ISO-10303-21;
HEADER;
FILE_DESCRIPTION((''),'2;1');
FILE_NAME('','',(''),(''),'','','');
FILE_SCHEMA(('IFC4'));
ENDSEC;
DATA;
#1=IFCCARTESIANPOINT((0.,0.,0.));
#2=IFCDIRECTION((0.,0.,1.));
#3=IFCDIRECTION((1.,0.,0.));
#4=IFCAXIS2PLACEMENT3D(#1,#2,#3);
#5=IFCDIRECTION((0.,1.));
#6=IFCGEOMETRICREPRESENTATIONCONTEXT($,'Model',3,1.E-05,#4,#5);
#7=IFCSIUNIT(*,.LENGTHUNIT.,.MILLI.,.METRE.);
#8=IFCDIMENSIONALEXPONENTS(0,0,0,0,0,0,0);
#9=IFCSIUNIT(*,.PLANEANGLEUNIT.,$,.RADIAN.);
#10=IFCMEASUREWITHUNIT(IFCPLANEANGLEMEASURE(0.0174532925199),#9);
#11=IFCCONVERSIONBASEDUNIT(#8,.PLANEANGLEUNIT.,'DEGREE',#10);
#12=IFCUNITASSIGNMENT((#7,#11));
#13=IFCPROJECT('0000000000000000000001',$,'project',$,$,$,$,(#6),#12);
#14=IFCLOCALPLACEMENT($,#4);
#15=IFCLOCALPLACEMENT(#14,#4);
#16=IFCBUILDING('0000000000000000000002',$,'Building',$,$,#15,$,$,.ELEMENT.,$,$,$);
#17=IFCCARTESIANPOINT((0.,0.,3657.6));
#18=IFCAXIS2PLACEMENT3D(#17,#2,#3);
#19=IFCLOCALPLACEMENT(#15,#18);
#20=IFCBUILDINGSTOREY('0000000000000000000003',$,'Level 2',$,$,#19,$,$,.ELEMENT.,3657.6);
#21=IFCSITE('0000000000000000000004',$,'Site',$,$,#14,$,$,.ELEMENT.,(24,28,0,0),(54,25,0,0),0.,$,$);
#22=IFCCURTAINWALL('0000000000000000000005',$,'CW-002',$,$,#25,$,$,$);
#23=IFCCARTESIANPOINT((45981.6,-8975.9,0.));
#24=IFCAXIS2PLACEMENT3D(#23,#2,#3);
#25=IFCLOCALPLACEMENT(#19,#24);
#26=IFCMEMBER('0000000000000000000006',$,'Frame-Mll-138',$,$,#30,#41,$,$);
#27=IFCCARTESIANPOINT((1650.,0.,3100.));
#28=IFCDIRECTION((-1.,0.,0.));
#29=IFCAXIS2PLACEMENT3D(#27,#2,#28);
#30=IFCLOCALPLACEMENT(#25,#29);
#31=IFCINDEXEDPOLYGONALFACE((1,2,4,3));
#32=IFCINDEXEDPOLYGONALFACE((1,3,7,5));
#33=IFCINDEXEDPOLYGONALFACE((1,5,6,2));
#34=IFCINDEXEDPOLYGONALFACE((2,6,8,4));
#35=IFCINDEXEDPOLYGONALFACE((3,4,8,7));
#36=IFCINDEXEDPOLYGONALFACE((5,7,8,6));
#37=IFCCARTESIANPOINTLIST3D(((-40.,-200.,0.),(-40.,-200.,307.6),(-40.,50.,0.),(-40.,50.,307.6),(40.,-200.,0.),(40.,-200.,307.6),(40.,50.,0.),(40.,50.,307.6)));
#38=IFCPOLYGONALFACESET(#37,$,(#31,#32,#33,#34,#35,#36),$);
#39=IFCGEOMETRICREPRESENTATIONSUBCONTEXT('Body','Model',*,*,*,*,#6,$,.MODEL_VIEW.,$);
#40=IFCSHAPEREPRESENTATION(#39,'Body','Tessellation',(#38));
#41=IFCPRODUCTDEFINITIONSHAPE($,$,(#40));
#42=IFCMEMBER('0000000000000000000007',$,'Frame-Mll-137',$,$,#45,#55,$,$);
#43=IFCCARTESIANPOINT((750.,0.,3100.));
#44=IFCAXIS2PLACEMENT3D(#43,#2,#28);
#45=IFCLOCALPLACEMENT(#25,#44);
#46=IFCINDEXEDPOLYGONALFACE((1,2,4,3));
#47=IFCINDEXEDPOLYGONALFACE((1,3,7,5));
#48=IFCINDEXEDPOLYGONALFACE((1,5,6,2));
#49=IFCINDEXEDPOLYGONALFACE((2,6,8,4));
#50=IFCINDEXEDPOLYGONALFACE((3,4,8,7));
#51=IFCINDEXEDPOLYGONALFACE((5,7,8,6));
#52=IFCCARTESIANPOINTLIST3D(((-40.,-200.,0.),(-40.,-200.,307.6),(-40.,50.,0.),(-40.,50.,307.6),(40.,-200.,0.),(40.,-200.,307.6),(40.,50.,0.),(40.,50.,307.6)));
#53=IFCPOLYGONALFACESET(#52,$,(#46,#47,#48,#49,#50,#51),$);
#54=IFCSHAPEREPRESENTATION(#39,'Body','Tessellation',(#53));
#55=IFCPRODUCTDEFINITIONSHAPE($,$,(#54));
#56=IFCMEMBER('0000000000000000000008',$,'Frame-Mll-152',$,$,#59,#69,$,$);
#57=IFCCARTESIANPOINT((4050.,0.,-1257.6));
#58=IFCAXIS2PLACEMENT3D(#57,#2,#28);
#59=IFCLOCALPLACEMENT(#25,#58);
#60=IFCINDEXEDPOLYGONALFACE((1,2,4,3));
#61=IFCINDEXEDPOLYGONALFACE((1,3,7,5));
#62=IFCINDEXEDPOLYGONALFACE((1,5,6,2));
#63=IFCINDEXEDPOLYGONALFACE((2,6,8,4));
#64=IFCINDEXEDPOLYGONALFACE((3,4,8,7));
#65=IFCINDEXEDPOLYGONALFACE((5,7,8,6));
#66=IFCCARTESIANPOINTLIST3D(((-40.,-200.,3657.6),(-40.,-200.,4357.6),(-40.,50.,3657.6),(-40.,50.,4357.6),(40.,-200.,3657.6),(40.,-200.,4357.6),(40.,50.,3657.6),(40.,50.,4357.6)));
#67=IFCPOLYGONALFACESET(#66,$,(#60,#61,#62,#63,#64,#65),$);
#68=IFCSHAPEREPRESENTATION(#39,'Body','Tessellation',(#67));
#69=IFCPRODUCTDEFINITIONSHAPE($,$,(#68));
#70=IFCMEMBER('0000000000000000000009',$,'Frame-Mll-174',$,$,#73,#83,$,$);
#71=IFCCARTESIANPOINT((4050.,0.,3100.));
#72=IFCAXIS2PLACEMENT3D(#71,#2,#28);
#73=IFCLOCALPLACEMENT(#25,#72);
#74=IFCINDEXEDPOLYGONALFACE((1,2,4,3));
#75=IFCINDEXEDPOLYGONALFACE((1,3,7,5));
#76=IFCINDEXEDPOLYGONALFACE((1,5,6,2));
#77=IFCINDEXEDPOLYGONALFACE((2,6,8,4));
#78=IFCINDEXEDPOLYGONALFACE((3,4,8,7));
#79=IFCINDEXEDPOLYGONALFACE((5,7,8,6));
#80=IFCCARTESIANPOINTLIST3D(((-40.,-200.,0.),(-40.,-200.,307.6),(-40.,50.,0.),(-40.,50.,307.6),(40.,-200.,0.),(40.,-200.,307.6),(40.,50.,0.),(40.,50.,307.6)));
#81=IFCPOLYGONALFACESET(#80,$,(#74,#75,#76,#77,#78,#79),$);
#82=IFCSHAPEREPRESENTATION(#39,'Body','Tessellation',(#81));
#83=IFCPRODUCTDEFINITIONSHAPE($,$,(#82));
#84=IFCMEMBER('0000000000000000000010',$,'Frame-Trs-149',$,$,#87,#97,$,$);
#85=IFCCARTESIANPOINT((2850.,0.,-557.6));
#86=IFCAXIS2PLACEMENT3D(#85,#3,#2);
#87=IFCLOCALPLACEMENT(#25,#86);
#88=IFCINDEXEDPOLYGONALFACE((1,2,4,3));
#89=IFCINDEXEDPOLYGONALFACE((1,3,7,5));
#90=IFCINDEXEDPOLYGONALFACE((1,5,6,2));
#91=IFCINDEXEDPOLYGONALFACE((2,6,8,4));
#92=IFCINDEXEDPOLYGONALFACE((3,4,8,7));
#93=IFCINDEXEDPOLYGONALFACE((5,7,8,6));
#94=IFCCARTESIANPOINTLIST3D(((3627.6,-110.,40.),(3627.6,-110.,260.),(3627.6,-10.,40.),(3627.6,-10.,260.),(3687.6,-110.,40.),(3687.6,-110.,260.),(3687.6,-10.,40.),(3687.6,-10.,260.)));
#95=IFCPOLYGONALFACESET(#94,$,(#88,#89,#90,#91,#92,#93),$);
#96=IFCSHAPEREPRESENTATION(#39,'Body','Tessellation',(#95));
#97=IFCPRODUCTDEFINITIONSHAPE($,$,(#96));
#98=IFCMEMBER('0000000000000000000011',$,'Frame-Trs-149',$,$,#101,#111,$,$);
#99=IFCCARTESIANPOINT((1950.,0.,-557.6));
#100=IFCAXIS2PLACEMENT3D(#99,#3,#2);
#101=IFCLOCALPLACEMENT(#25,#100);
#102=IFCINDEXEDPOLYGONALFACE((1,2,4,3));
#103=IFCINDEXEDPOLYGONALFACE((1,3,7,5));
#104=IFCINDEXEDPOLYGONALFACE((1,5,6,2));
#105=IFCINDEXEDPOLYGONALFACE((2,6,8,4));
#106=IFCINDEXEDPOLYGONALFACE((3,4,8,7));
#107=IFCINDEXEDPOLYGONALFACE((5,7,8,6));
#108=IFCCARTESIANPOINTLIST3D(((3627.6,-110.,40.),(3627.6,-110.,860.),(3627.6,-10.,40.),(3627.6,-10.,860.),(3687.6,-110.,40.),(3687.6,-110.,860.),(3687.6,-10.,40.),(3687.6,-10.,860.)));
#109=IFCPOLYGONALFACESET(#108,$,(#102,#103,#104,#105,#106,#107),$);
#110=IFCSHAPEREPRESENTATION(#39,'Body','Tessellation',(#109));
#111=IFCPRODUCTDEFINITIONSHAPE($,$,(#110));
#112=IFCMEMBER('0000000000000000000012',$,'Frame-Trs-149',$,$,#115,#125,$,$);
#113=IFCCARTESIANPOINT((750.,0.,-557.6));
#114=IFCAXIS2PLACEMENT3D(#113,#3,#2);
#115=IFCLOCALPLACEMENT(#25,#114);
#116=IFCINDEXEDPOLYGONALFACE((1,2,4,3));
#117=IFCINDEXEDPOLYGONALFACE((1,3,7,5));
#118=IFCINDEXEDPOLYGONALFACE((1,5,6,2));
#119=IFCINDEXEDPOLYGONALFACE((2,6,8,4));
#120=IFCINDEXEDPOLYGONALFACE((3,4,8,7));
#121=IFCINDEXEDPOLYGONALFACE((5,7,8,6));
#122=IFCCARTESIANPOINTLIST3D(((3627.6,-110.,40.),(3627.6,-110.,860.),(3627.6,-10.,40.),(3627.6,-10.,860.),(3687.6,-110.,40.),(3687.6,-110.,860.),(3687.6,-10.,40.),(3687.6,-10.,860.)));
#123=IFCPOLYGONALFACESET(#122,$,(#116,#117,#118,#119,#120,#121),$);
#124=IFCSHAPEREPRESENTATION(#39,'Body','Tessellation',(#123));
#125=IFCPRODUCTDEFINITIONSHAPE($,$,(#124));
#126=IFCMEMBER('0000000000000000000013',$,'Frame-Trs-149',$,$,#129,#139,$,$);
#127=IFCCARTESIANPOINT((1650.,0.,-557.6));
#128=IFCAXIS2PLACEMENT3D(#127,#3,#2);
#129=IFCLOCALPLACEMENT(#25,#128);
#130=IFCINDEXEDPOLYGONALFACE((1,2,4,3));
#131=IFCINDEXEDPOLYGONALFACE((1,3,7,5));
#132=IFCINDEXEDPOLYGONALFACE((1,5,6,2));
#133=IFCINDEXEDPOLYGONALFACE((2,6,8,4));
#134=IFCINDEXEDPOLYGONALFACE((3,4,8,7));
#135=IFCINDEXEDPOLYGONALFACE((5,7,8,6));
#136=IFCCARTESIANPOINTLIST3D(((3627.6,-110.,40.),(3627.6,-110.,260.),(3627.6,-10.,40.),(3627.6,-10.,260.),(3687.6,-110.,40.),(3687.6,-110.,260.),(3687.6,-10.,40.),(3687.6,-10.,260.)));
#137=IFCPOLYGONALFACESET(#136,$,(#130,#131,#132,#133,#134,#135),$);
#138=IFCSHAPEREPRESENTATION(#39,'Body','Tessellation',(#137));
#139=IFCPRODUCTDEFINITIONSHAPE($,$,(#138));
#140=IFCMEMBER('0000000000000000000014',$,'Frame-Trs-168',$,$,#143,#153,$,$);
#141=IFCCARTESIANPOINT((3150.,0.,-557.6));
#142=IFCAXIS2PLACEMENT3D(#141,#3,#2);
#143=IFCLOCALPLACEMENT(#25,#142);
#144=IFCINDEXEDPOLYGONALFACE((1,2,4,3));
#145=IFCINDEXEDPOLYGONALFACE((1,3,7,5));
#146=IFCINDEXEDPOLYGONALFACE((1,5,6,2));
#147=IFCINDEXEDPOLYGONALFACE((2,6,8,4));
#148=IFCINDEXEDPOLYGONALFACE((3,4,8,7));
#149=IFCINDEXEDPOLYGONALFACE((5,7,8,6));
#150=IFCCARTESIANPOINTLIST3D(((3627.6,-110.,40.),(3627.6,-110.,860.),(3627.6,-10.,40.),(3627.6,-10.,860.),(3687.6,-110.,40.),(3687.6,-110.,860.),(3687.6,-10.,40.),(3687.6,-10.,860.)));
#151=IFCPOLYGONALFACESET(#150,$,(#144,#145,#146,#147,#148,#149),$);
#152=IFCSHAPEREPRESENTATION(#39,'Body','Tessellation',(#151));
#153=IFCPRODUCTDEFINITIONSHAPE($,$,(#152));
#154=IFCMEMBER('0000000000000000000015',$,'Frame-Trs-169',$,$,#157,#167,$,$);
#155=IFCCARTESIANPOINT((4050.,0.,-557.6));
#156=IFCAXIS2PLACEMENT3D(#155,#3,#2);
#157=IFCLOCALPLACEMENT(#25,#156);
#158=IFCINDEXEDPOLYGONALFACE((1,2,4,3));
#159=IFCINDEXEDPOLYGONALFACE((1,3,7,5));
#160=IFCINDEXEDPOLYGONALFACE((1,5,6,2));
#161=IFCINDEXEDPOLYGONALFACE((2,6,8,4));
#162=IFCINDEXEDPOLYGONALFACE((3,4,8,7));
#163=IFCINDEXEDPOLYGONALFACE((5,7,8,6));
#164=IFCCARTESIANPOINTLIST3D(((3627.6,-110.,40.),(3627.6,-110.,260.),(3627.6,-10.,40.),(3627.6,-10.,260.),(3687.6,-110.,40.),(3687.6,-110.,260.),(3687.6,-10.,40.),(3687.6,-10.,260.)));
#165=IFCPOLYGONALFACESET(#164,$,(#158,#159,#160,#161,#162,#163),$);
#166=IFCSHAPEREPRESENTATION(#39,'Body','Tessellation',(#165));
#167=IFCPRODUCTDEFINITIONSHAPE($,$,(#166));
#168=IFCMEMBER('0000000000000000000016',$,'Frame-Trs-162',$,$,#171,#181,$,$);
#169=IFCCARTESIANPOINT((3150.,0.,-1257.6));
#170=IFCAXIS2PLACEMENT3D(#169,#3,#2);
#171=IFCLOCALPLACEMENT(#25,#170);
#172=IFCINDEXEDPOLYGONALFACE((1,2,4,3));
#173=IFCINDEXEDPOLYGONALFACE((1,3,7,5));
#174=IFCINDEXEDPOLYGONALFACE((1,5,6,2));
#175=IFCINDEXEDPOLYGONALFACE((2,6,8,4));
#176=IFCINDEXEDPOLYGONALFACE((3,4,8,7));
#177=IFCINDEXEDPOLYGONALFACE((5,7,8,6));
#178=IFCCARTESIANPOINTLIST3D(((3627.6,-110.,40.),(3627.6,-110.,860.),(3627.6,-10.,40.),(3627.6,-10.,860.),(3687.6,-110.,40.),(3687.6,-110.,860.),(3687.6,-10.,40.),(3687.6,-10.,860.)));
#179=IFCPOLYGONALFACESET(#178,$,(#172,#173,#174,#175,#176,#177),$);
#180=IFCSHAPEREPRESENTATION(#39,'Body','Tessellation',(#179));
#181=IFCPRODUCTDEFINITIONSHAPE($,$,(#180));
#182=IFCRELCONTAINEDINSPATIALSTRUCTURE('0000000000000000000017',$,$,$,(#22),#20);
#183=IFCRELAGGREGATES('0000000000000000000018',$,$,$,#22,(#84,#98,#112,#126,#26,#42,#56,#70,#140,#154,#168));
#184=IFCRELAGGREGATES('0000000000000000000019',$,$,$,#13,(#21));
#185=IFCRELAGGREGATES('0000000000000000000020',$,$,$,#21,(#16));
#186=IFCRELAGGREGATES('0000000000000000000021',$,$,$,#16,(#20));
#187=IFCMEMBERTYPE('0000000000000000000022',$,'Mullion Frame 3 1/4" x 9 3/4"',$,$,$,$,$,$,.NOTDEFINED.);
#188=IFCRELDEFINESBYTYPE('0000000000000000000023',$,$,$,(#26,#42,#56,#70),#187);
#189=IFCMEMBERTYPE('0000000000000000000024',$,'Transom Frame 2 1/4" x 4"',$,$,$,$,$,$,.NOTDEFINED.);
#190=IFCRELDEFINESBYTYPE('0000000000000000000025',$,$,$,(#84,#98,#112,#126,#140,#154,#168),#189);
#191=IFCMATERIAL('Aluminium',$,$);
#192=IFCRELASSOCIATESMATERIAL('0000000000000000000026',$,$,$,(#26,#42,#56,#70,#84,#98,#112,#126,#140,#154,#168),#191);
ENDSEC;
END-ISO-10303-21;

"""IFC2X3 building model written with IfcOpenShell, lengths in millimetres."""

from ifc_helpers import new_model, entity, si_unit, converted_unit, direction, frame, origin_with_axes, place, context, subcontext, project, spatial, polyline, outline, extrude, material, type_object, element, aggregate, save


model = new_model("IFC2X3")

# Units and contexts
model_context = context("Model", 3, precision=1e-05, world=origin_with_axes(), true_north=direction((0.0, 1.0)))
body_context = subcontext(model_context, "Body", "Model", "MODEL_VIEW")
ifc_project = project(units=[si_unit("LENGTHUNIT", "METRE", prefix="MILLI"), converted_unit("PLANEANGLEUNIT", "DEGREE", entity("IfcPlaneAngleMeasure", 0.0174532925199), si_unit("PLANEANGLEUNIT", "RADIAN"), dimensions=[0, 0, 0, 0, 0, 0, 0])], contexts=[model_context])

# Site, building, storey
site_placement = place(None, origin_with_axes())
site = spatial("IfcSite", under=ifc_project, at=site_placement, Name="Site", CompositionType="ELEMENT", RefLatitude=(24, 28, 0, 0), RefLongitude=(54, 25, 0, 0), RefElevation=0.0)
building_placement = place(site_placement, origin_with_axes())
building = spatial("IfcBuilding", under=site, at=building_placement, Name="Building", CompositionType="ELEMENT")
storey_placement = place(building_placement, frame((0.0, 0.0, 3657.6), z_axis=(0.0, 0.0, 1.0), x_axis=(1.0, 0.0, 0.0)))
storey = spatial("IfcBuildingStorey", under=building, at=storey_placement, Name="Level 2", CompositionType="ELEMENT", Elevation=3657.6)

# Curtain wall, members
curtain_wall_placement = place(storey_placement, frame((45981.6, -8975.9, 0.0), z_axis=(0.0, 0.0, 1.0), x_axis=(1.0, 0.0, 0.0)))
curtain_wall = element("IfcCurtainWall", 1, at=curtain_wall_placement, inside=storey, Name="CW-002")
ifc_material_1 = material(Name="Aluminium")
member_type_1 = type_object("IfcMemberType", Name="Mullion Frame 3 1/4\" x 9 3/4\"", PredefinedType="NOTDEFINED")
member_1_placement = place(curtain_wall_placement, frame((1650.0, 0.0, 3100.0), z_axis=(0.0, 0.0, 1.0), x_axis=(-1.0, 0.0, 0.0)))
member_1 = element("IfcMember", 2, at=member_1_placement, type_object=member_type_1, material=ifc_material_1, Name="Frame-Mll-138", context=body_context, shape_type="SweptSolid", body=[
    extrude(outline(polyline([(-40.0, 200.0), (-40.0, -50.0), (40.0, -50.0), (40.0, 200.0), (-40.0, 200.0)])), frame((0.0, 0.0, 0.0), z_axis=(0.0, 0.0, 1.0), x_axis=(-1.0, 0.0, 0.0)), (0.0, 0.0, 1.0), 307.6),
])
member_2_placement = place(curtain_wall_placement, frame((750.0, 0.0, 3100.0), z_axis=(0.0, 0.0, 1.0), x_axis=(-1.0, 0.0, 0.0)))
member_2 = element("IfcMember", 3, at=member_2_placement, type_object=member_type_1, material=ifc_material_1, Name="Frame-Mll-137", context=body_context, shape_type="SweptSolid", body=[
    extrude(outline(polyline([(-40.0, 200.0), (-40.0, -50.0), (40.0, -50.0), (40.0, 200.0), (-40.0, 200.0)])), frame((0.0, 0.0, 0.0), z_axis=(0.0, 0.0, 1.0), x_axis=(-1.0, 0.0, 0.0)), (0.0, 0.0, 1.0), 307.6),
])
member_3_placement = place(curtain_wall_placement, frame((4050.0, 0.0, -1257.6), z_axis=(0.0, 0.0, 1.0), x_axis=(-1.0, 0.0, 0.0)))
member_3 = element("IfcMember", 4, at=member_3_placement, type_object=member_type_1, material=ifc_material_1, Name="Frame-Mll-152", context=body_context, shape_type="SweptSolid", body=[
    extrude(outline(polyline([(-40.0, 200.0), (-40.0, -50.0), (40.0, -50.0), (40.0, 200.0), (-40.0, 200.0)])), frame((0.0, 0.0, 3657.6), z_axis=(0.0, 0.0, 1.0), x_axis=(-1.0, 0.0, 0.0)), (0.0, 0.0, 1.0), 700.0),
])
member_4_placement = place(curtain_wall_placement, frame((4050.0, 0.0, 3100.0), z_axis=(0.0, 0.0, 1.0), x_axis=(-1.0, 0.0, 0.0)))
member_4 = element("IfcMember", 5, at=member_4_placement, type_object=member_type_1, material=ifc_material_1, Name="Frame-Mll-174", context=body_context, shape_type="SweptSolid", body=[
    extrude(outline(polyline([(-40.0, 200.0), (-40.0, -50.0), (40.0, -50.0), (40.0, 200.0), (-40.0, 200.0)])), frame((0.0, 0.0, 0.0), z_axis=(0.0, 0.0, 1.0), x_axis=(-1.0, 0.0, 0.0)), (0.0, 0.0, 1.0), 307.6),
])
member_type_2 = type_object("IfcMemberType", Name="Transom Frame 2 1/4\" x 4\"", PredefinedType="NOTDEFINED")
member_5_placement = place(curtain_wall_placement, frame((2850.0, 0.0, -557.6), z_axis=(1.0, 0.0, 0.0), x_axis=(0.0, 0.0, 1.0)))
member_5 = element("IfcMember", 6, at=member_5_placement, type_object=member_type_2, material=ifc_material_1, Name="Frame-Trs-149", context=body_context, shape_type="SweptSolid", body=[
    extrude(outline(polyline([(-110.0, -3687.6), (-10.0, -3687.6), (-10.0, -3627.6), (-110.0, -3627.6), (-110.0, -3687.6)])), frame((0.0, 0.0, 40.0), z_axis=(0.0, 0.0, 1.0), x_axis=(0.0, 1.0, 0.0)), (0.0, 0.0, 1.0), 220.0),
])
member_6_placement = place(curtain_wall_placement, frame((1950.0, 0.0, -557.6), z_axis=(1.0, 0.0, 0.0), x_axis=(0.0, 0.0, 1.0)))
member_6 = element("IfcMember", 7, at=member_6_placement, type_object=member_type_2, material=ifc_material_1, Name="Frame-Trs-149", context=body_context, shape_type="SweptSolid", body=[
    extrude(outline(polyline([(-110.0, -3687.6), (-10.0, -3687.6), (-10.0, -3627.6), (-110.0, -3627.6), (-110.0, -3687.6)])), frame((0.0, 0.0, 40.0), z_axis=(0.0, 0.0, 1.0), x_axis=(0.0, 1.0, 0.0)), (0.0, 0.0, 1.0), 820.0),
])
member_7_placement = place(curtain_wall_placement, frame((750.0, 0.0, -557.6), z_axis=(1.0, 0.0, 0.0), x_axis=(0.0, 0.0, 1.0)))
member_7 = element("IfcMember", 8, at=member_7_placement, type_object=member_type_2, material=ifc_material_1, Name="Frame-Trs-149", context=body_context, shape_type="SweptSolid", body=[
    extrude(outline(polyline([(-110.0, -3687.6), (-10.0, -3687.6), (-10.0, -3627.6), (-110.0, -3627.6), (-110.0, -3687.6)])), frame((0.0, 0.0, 40.0), z_axis=(0.0, 0.0, 1.0), x_axis=(0.0, 1.0, 0.0)), (0.0, 0.0, 1.0), 820.0),
])
member_8_placement = place(curtain_wall_placement, frame((1650.0, 0.0, -557.6), z_axis=(1.0, 0.0, 0.0), x_axis=(0.0, 0.0, 1.0)))
member_8 = element("IfcMember", 9, at=member_8_placement, type_object=member_type_2, material=ifc_material_1, Name="Frame-Trs-149", context=body_context, shape_type="SweptSolid", body=[
    extrude(outline(polyline([(-110.0, -3687.6), (-10.0, -3687.6), (-10.0, -3627.6), (-110.0, -3627.6), (-110.0, -3687.6)])), frame((0.0, 0.0, 40.0), z_axis=(0.0, 0.0, 1.0), x_axis=(0.0, 1.0, 0.0)), (0.0, 0.0, 1.0), 220.0),
])
member_9_placement = place(curtain_wall_placement, frame((3150.0, 0.0, -557.6), z_axis=(1.0, 0.0, 0.0), x_axis=(0.0, 0.0, 1.0)))
member_9 = element("IfcMember", 10, at=member_9_placement, type_object=member_type_2, material=ifc_material_1, Name="Frame-Trs-168", context=body_context, shape_type="SweptSolid", body=[
    extrude(outline(polyline([(-110.0, -3687.6), (-10.0, -3687.6), (-10.0, -3627.6), (-110.0, -3627.6), (-110.0, -3687.6)])), frame((0.0, 0.0, 40.0), z_axis=(0.0, 0.0, 1.0), x_axis=(0.0, 1.0, 0.0)), (0.0, 0.0, 1.0), 820.0),
])
member_10_placement = place(curtain_wall_placement, frame((4050.0, 0.0, -557.6), z_axis=(1.0, 0.0, 0.0), x_axis=(0.0, 0.0, 1.0)))
member_10 = element("IfcMember", 11, at=member_10_placement, type_object=member_type_2, material=ifc_material_1, Name="Frame-Trs-169", context=body_context, shape_type="SweptSolid", body=[
    extrude(outline(polyline([(-110.0, -3687.6), (-10.0, -3687.6), (-10.0, -3627.6), (-110.0, -3627.6), (-110.0, -3687.6)])), frame((0.0, 0.0, 40.0), z_axis=(0.0, 0.0, 1.0), x_axis=(0.0, 1.0, 0.0)), (0.0, 0.0, 1.0), 220.0),
])
member_11_placement = place(curtain_wall_placement, frame((3150.0, 0.0, -1257.6), z_axis=(1.0, 0.0, 0.0), x_axis=(0.0, 0.0, 1.0)))
member_11 = element("IfcMember", 12, at=member_11_placement, type_object=member_type_2, material=ifc_material_1, Name="Frame-Trs-162", context=body_context, shape_type="SweptSolid", body=[
    extrude(outline(polyline([(-110.0, -3687.6), (-10.0, -3687.6), (-10.0, -3627.6), (-110.0, -3627.6), (-110.0, -3687.6)])), frame((0.0, 0.0, 40.0), z_axis=(0.0, 0.0, 1.0), x_axis=(0.0, 1.0, 0.0)), (0.0, 0.0, 1.0), 820.0),
])
aggregate(curtain_wall, [member_5, member_6, member_7, member_8, member_1, member_2, member_3, member_4, member_9, member_10, member_11])

save(model, "model.ifc")
